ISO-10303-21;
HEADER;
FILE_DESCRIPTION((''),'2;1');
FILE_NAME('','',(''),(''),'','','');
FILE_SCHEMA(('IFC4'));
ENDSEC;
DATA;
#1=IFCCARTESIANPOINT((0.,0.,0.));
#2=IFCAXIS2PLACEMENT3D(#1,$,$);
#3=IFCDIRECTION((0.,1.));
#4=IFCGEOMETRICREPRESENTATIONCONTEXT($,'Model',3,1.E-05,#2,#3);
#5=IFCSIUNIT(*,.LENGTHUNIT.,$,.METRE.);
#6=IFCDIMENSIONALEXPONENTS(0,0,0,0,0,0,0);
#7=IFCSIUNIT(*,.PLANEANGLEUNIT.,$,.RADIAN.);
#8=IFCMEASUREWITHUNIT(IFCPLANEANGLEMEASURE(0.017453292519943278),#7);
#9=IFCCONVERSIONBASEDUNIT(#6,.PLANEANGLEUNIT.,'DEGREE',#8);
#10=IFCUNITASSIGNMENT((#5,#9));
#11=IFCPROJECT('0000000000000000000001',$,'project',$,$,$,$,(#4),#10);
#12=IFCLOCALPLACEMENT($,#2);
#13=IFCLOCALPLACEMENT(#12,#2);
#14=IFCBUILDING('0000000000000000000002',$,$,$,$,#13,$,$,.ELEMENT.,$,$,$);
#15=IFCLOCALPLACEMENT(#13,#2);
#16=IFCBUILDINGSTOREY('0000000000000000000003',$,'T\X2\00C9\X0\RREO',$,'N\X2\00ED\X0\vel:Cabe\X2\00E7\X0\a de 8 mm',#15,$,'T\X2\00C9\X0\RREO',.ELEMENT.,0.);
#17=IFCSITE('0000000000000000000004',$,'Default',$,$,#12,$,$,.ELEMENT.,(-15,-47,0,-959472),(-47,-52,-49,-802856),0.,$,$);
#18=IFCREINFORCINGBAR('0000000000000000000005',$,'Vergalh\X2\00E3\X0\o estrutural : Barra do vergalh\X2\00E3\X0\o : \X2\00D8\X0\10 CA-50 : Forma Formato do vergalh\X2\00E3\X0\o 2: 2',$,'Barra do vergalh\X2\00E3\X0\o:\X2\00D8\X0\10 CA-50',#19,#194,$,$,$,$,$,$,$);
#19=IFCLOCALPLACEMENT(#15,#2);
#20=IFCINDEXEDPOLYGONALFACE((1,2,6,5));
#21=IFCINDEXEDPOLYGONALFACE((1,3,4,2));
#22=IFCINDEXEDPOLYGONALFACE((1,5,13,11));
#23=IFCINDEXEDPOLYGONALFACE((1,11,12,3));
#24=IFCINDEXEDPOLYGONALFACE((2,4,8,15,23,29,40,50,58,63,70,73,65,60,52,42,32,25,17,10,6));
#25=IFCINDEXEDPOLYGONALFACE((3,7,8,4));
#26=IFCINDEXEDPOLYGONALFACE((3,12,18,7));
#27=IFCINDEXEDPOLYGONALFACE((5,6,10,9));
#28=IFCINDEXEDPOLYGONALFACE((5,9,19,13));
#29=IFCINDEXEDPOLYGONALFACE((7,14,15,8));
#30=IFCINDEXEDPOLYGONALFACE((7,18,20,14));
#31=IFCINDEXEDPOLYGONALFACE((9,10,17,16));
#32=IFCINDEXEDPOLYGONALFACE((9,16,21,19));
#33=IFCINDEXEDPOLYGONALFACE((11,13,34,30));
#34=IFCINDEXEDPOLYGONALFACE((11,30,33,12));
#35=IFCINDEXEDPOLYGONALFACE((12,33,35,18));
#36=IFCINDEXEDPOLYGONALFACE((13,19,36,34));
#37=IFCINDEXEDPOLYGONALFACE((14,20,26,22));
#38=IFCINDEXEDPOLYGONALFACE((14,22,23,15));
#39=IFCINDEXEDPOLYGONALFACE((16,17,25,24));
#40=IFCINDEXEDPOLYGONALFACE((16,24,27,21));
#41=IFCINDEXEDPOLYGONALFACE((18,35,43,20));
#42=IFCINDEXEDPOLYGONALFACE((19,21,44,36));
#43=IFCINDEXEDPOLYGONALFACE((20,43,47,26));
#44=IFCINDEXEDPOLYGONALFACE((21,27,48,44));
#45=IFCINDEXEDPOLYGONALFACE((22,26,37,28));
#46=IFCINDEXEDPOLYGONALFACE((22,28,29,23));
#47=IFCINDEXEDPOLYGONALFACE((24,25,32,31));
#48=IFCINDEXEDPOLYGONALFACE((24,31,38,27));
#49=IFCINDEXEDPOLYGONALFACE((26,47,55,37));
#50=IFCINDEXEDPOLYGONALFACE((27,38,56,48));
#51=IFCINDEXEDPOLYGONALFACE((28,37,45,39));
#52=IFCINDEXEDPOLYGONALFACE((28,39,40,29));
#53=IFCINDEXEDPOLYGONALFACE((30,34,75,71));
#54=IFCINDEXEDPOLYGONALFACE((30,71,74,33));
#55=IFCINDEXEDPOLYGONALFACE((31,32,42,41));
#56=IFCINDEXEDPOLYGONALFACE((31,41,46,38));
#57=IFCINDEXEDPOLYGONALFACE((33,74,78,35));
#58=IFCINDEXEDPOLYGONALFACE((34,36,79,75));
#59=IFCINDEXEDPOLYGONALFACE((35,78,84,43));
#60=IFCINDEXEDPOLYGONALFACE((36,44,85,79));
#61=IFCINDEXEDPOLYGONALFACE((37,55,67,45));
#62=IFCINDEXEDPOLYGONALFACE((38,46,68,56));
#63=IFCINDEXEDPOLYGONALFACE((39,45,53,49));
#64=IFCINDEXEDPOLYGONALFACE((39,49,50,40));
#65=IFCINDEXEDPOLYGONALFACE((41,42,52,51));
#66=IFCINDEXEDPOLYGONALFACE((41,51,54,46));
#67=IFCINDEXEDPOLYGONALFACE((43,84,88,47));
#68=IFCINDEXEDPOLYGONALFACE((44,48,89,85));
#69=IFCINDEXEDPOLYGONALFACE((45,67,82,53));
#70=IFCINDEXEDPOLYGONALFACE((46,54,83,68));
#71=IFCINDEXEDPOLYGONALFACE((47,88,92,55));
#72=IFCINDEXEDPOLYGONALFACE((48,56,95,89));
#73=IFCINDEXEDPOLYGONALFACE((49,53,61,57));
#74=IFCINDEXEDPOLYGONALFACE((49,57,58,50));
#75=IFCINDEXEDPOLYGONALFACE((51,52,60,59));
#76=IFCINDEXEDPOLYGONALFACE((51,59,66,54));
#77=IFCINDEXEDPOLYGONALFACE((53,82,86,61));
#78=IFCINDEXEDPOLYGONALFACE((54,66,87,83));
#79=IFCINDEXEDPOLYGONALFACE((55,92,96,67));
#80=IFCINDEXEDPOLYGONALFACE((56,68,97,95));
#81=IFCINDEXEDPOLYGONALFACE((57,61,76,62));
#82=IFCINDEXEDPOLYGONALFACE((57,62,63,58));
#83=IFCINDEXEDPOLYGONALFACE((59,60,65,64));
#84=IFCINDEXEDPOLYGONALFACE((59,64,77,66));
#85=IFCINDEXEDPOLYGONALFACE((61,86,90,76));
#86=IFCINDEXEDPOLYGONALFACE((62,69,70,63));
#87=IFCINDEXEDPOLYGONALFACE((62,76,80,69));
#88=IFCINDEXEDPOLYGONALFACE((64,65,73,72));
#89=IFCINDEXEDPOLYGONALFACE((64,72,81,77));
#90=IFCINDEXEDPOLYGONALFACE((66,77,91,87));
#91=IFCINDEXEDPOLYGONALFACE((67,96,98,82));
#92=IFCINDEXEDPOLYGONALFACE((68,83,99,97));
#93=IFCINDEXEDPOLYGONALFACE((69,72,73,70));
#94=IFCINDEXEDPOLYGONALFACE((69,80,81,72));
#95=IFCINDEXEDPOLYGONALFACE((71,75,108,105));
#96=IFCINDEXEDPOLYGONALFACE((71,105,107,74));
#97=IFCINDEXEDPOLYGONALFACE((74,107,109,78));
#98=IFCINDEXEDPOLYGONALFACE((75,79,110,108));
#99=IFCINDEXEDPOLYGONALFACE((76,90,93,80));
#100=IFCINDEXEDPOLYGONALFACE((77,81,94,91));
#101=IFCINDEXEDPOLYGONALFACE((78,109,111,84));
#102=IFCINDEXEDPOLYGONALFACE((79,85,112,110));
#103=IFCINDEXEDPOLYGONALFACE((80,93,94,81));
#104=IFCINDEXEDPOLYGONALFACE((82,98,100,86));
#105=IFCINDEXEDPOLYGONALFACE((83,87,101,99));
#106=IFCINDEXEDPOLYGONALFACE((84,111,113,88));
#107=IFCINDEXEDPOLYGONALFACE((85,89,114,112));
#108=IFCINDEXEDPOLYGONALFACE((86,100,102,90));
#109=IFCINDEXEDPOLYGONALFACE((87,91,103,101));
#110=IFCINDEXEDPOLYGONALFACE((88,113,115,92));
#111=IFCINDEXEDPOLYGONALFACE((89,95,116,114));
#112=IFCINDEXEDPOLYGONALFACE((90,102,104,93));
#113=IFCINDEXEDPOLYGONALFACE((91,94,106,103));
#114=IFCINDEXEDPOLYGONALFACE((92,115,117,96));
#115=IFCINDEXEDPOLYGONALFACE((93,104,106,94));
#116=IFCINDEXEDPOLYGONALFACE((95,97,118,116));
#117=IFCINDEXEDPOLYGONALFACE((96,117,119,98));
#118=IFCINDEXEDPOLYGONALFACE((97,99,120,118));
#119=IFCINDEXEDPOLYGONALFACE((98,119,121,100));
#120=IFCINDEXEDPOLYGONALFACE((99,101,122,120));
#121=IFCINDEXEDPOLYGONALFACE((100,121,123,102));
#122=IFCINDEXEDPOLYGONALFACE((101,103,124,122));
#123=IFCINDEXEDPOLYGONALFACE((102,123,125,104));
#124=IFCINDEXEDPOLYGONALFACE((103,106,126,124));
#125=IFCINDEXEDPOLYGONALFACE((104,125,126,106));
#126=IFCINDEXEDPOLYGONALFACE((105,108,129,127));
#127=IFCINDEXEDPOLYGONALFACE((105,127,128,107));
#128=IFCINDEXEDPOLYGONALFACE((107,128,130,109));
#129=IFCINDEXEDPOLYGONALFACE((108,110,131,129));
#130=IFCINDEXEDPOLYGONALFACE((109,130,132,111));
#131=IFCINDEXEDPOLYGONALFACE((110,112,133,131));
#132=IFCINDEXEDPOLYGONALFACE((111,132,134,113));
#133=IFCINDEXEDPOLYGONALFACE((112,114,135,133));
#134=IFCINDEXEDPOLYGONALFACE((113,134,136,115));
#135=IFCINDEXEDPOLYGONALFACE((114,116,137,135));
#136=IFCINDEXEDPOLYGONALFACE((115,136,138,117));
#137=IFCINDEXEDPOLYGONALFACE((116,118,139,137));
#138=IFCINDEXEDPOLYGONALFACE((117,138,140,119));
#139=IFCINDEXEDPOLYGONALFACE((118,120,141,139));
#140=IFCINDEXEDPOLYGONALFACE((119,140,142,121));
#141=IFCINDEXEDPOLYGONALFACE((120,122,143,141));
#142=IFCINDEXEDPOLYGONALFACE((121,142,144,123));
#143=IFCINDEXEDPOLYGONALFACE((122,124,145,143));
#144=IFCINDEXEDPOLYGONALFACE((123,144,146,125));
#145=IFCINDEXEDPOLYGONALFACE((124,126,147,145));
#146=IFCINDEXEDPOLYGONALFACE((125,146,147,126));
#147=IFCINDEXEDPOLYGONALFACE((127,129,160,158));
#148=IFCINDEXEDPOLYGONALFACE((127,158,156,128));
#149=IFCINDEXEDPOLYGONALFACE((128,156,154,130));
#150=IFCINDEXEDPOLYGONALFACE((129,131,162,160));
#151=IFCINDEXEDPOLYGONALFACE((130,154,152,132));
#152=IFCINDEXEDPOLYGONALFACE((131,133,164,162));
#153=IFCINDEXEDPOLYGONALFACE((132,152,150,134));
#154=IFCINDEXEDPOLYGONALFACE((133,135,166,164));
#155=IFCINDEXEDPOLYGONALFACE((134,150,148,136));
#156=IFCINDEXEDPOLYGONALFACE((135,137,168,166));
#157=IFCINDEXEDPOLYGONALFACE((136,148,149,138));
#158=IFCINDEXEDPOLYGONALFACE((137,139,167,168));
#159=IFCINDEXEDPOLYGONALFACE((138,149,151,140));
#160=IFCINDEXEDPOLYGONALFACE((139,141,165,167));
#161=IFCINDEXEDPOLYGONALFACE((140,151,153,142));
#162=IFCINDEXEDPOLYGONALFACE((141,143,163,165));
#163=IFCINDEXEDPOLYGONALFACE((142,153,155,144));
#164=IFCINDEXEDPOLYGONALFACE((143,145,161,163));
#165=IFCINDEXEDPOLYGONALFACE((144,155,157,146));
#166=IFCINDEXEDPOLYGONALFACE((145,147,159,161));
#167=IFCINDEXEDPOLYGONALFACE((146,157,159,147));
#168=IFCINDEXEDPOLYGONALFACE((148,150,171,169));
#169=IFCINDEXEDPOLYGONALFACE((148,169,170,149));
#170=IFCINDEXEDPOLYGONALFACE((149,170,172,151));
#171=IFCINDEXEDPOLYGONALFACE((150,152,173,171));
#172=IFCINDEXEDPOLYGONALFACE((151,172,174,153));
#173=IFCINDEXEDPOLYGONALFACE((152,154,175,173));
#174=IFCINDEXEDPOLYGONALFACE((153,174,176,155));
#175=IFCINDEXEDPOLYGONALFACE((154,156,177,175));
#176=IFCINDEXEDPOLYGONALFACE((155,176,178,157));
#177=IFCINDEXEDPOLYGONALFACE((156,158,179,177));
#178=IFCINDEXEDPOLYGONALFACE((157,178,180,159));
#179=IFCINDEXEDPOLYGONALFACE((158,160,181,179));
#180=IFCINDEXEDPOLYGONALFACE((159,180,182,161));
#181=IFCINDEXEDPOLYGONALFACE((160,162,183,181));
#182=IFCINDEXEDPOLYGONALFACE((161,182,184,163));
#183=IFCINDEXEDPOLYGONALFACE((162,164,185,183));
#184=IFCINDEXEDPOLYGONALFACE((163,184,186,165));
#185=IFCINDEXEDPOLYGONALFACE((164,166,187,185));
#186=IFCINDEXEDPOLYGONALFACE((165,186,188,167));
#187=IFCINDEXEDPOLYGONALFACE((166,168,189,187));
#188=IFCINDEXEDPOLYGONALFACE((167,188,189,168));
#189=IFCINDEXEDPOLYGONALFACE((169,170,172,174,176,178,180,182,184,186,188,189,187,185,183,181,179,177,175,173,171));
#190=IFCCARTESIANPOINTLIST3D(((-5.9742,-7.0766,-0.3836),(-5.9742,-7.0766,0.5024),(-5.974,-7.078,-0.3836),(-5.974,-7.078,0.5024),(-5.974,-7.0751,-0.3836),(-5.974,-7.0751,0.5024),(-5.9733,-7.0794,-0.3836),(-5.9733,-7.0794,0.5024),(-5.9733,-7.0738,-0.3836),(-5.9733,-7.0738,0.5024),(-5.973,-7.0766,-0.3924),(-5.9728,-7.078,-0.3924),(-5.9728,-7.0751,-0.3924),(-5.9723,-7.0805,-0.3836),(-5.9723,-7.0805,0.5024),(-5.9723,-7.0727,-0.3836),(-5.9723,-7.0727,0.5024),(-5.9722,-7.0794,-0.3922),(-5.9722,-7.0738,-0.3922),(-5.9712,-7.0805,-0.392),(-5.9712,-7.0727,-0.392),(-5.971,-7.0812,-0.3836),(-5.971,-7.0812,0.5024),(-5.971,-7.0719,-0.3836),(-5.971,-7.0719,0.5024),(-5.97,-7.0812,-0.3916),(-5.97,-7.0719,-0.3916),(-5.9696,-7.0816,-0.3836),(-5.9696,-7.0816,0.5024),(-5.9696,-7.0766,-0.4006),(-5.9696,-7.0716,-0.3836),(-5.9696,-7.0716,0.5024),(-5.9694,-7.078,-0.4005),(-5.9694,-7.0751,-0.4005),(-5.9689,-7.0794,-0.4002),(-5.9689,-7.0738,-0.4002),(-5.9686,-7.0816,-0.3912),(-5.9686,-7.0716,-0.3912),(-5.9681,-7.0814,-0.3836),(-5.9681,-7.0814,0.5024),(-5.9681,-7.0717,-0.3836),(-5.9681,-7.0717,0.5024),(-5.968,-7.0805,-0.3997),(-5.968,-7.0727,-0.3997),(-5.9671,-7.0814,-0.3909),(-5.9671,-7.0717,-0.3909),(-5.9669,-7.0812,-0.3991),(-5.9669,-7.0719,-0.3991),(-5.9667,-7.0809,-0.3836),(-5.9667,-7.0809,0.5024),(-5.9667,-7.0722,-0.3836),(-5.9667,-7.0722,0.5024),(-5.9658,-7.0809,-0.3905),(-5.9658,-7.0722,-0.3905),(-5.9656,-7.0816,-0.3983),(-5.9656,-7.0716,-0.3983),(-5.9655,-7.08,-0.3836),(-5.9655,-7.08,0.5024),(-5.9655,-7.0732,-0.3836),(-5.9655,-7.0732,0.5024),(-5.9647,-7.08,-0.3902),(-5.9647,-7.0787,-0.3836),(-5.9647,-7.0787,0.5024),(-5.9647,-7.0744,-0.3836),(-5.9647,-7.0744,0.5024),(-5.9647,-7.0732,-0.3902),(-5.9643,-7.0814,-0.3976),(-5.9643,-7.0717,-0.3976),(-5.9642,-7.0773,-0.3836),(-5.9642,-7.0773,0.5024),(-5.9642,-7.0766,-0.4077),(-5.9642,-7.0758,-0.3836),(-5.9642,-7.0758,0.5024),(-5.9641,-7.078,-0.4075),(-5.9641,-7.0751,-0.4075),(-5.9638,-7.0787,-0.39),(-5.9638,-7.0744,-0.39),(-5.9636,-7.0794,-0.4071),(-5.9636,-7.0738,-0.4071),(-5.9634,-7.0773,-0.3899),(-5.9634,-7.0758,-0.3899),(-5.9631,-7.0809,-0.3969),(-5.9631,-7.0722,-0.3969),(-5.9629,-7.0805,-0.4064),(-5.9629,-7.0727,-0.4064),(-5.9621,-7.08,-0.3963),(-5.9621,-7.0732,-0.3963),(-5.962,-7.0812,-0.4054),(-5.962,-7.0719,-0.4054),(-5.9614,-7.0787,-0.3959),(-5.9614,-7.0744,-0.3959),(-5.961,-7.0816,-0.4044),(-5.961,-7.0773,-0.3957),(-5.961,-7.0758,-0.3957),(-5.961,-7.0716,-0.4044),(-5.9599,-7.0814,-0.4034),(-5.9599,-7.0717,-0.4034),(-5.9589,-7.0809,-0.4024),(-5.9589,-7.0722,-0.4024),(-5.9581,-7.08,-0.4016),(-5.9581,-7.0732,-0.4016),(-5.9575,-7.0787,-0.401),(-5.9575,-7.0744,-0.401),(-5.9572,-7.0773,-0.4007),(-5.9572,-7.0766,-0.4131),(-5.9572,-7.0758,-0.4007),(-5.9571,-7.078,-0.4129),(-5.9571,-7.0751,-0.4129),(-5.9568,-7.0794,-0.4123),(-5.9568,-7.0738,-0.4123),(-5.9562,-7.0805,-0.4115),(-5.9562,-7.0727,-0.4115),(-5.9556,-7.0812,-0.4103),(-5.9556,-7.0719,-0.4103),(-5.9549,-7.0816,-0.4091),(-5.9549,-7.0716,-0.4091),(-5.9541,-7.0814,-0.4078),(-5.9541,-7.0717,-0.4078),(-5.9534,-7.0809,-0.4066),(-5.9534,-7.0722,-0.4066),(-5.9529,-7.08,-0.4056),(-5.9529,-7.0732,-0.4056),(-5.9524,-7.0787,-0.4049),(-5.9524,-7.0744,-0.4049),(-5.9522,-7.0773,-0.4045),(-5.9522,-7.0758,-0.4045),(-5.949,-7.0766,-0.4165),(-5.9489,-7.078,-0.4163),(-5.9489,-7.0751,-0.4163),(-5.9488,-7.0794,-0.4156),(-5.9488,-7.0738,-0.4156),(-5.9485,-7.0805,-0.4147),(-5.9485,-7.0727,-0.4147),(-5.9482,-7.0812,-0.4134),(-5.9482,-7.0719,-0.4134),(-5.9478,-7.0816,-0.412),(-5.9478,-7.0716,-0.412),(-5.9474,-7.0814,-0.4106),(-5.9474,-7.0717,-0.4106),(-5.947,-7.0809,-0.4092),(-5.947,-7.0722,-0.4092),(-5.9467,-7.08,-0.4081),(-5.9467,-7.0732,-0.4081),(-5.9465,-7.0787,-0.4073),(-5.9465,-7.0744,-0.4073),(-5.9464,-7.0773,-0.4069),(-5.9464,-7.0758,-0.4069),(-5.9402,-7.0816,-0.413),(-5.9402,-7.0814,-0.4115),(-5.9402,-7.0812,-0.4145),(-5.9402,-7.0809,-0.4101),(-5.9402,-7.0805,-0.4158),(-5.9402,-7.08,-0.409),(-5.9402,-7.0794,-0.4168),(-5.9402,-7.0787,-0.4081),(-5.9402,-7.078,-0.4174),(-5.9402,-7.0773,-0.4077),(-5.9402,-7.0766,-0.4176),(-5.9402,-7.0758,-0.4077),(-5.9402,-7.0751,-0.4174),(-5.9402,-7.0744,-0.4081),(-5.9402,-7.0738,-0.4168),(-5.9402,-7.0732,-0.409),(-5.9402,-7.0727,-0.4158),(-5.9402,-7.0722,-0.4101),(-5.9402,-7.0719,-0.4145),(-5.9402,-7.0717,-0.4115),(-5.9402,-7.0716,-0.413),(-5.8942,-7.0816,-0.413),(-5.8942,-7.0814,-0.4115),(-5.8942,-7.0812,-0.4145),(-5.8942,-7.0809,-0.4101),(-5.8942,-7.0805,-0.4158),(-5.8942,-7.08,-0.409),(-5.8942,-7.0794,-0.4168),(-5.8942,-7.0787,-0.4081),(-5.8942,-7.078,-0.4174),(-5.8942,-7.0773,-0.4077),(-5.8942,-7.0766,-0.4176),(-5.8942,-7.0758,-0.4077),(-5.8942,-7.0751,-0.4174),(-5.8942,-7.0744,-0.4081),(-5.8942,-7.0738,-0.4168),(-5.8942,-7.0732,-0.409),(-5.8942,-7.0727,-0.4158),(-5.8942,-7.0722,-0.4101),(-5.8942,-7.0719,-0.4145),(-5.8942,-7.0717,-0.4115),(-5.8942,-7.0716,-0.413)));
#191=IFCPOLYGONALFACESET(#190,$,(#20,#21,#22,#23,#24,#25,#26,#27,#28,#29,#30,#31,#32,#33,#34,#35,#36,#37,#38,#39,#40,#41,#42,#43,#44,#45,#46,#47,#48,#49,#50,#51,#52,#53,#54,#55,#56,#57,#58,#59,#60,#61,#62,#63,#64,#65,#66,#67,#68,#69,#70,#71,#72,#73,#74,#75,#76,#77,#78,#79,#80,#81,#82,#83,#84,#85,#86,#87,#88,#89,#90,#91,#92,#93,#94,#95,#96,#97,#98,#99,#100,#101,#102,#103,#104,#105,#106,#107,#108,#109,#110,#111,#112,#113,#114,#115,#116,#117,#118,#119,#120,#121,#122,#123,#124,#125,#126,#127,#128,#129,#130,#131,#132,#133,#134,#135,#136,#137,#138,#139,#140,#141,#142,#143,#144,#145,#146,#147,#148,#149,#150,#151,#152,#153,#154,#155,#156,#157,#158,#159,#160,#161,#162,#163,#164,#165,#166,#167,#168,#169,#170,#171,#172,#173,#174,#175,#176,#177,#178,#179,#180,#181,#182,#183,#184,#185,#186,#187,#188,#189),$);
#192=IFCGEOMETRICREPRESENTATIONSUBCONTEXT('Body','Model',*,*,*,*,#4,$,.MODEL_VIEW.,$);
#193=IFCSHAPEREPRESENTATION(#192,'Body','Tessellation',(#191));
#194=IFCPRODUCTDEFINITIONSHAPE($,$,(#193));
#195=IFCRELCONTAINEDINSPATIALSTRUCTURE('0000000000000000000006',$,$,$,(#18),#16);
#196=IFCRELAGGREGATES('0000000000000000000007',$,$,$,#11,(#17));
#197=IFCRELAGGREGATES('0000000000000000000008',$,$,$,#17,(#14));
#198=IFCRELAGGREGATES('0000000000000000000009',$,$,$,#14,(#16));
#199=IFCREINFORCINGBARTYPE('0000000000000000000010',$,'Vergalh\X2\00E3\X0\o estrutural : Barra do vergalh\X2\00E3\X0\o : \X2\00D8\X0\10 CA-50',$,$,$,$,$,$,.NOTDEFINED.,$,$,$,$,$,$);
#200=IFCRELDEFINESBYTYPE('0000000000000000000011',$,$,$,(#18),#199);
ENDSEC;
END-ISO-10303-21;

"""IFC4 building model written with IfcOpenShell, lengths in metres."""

from ifc_helpers import new_model, entity, si_unit, converted_unit, direction, origin, place, context, subcontext, project, spatial, type_object, element, save


model = new_model("IFC4")

# Units and contexts
model_context = context("Model", 3, precision=1e-05, world=origin(), true_north=direction((0.0, 1.0)))
body_context = subcontext(model_context, "Body", "Model", "MODEL_VIEW")
ifc_project = project(units=[si_unit("LENGTHUNIT", "METRE"), converted_unit("PLANEANGLEUNIT", "DEGREE", entity("IfcPlaneAngleMeasure", 0.017453292519943278), si_unit("PLANEANGLEUNIT", "RADIAN"), dimensions=[0, 0, 0, 0, 0, 0, 0])], contexts=[model_context])

# Site, building, storey
site_placement = place(None, origin())
site = spatial("IfcSite", under=ifc_project, at=site_placement, Name="Default", CompositionType="ELEMENT", RefLatitude=(-15, -47, 0, -959472), RefLongitude=(-47, -52, -49, -802856), RefElevation=0.0)
building_placement = place(site_placement, origin())
building = spatial("IfcBuilding", under=site, at=building_placement, CompositionType="ELEMENT")
storey_placement = place(building_placement, origin())
storey = spatial("IfcBuildingStorey", under=building, at=storey_placement, Name="TÉRREO", ObjectType="Nível:Cabeça de 8 mm", LongName="TÉRREO", CompositionType="ELEMENT", Elevation=0.0)

# Reinforcing bar
reinforcing_bar_type_1 = type_object("IfcReinforcingBarType", Name="Vergalhão estrutural : Barra do vergalhão : Ø10 CA-50", PredefinedType="NOTDEFINED")
reinforcing_bar_1_placement = place(storey_placement, origin())
element("IfcReinforcingBar", 1, at=reinforcing_bar_1_placement, inside=storey, type_object=reinforcing_bar_type_1, Name="Vergalhão estrutural : Barra do vergalhão : Ø10 CA-50 : Forma Formato do vergalhão 2: 2", ObjectType="Barra do vergalhão:Ø10 CA-50", context=body_context, shape_type="AdvancedSweptSolid", body=[
    entity("IfcSweptDiskSolid", entity("IfcIndexedPolyCurve", entity("IfcCartesianPointList3D", [[-5.8942, -7.0766, -0.4126], [-5.9402, -7.0766, -0.4126], [-5.9607, -7.0766, -0.4042], [-5.9692, -7.0766, -0.3836], [-5.9692, -7.0766, 0.5024]]), [entity("IfcLineIndex", [1, 2]), entity("IfcArcIndex", [2, 3, 4]), entity("IfcLineIndex", [4, 5])], False), 0.005, None, 0.0, 92.0),
])

save(model, "model.ifc")
